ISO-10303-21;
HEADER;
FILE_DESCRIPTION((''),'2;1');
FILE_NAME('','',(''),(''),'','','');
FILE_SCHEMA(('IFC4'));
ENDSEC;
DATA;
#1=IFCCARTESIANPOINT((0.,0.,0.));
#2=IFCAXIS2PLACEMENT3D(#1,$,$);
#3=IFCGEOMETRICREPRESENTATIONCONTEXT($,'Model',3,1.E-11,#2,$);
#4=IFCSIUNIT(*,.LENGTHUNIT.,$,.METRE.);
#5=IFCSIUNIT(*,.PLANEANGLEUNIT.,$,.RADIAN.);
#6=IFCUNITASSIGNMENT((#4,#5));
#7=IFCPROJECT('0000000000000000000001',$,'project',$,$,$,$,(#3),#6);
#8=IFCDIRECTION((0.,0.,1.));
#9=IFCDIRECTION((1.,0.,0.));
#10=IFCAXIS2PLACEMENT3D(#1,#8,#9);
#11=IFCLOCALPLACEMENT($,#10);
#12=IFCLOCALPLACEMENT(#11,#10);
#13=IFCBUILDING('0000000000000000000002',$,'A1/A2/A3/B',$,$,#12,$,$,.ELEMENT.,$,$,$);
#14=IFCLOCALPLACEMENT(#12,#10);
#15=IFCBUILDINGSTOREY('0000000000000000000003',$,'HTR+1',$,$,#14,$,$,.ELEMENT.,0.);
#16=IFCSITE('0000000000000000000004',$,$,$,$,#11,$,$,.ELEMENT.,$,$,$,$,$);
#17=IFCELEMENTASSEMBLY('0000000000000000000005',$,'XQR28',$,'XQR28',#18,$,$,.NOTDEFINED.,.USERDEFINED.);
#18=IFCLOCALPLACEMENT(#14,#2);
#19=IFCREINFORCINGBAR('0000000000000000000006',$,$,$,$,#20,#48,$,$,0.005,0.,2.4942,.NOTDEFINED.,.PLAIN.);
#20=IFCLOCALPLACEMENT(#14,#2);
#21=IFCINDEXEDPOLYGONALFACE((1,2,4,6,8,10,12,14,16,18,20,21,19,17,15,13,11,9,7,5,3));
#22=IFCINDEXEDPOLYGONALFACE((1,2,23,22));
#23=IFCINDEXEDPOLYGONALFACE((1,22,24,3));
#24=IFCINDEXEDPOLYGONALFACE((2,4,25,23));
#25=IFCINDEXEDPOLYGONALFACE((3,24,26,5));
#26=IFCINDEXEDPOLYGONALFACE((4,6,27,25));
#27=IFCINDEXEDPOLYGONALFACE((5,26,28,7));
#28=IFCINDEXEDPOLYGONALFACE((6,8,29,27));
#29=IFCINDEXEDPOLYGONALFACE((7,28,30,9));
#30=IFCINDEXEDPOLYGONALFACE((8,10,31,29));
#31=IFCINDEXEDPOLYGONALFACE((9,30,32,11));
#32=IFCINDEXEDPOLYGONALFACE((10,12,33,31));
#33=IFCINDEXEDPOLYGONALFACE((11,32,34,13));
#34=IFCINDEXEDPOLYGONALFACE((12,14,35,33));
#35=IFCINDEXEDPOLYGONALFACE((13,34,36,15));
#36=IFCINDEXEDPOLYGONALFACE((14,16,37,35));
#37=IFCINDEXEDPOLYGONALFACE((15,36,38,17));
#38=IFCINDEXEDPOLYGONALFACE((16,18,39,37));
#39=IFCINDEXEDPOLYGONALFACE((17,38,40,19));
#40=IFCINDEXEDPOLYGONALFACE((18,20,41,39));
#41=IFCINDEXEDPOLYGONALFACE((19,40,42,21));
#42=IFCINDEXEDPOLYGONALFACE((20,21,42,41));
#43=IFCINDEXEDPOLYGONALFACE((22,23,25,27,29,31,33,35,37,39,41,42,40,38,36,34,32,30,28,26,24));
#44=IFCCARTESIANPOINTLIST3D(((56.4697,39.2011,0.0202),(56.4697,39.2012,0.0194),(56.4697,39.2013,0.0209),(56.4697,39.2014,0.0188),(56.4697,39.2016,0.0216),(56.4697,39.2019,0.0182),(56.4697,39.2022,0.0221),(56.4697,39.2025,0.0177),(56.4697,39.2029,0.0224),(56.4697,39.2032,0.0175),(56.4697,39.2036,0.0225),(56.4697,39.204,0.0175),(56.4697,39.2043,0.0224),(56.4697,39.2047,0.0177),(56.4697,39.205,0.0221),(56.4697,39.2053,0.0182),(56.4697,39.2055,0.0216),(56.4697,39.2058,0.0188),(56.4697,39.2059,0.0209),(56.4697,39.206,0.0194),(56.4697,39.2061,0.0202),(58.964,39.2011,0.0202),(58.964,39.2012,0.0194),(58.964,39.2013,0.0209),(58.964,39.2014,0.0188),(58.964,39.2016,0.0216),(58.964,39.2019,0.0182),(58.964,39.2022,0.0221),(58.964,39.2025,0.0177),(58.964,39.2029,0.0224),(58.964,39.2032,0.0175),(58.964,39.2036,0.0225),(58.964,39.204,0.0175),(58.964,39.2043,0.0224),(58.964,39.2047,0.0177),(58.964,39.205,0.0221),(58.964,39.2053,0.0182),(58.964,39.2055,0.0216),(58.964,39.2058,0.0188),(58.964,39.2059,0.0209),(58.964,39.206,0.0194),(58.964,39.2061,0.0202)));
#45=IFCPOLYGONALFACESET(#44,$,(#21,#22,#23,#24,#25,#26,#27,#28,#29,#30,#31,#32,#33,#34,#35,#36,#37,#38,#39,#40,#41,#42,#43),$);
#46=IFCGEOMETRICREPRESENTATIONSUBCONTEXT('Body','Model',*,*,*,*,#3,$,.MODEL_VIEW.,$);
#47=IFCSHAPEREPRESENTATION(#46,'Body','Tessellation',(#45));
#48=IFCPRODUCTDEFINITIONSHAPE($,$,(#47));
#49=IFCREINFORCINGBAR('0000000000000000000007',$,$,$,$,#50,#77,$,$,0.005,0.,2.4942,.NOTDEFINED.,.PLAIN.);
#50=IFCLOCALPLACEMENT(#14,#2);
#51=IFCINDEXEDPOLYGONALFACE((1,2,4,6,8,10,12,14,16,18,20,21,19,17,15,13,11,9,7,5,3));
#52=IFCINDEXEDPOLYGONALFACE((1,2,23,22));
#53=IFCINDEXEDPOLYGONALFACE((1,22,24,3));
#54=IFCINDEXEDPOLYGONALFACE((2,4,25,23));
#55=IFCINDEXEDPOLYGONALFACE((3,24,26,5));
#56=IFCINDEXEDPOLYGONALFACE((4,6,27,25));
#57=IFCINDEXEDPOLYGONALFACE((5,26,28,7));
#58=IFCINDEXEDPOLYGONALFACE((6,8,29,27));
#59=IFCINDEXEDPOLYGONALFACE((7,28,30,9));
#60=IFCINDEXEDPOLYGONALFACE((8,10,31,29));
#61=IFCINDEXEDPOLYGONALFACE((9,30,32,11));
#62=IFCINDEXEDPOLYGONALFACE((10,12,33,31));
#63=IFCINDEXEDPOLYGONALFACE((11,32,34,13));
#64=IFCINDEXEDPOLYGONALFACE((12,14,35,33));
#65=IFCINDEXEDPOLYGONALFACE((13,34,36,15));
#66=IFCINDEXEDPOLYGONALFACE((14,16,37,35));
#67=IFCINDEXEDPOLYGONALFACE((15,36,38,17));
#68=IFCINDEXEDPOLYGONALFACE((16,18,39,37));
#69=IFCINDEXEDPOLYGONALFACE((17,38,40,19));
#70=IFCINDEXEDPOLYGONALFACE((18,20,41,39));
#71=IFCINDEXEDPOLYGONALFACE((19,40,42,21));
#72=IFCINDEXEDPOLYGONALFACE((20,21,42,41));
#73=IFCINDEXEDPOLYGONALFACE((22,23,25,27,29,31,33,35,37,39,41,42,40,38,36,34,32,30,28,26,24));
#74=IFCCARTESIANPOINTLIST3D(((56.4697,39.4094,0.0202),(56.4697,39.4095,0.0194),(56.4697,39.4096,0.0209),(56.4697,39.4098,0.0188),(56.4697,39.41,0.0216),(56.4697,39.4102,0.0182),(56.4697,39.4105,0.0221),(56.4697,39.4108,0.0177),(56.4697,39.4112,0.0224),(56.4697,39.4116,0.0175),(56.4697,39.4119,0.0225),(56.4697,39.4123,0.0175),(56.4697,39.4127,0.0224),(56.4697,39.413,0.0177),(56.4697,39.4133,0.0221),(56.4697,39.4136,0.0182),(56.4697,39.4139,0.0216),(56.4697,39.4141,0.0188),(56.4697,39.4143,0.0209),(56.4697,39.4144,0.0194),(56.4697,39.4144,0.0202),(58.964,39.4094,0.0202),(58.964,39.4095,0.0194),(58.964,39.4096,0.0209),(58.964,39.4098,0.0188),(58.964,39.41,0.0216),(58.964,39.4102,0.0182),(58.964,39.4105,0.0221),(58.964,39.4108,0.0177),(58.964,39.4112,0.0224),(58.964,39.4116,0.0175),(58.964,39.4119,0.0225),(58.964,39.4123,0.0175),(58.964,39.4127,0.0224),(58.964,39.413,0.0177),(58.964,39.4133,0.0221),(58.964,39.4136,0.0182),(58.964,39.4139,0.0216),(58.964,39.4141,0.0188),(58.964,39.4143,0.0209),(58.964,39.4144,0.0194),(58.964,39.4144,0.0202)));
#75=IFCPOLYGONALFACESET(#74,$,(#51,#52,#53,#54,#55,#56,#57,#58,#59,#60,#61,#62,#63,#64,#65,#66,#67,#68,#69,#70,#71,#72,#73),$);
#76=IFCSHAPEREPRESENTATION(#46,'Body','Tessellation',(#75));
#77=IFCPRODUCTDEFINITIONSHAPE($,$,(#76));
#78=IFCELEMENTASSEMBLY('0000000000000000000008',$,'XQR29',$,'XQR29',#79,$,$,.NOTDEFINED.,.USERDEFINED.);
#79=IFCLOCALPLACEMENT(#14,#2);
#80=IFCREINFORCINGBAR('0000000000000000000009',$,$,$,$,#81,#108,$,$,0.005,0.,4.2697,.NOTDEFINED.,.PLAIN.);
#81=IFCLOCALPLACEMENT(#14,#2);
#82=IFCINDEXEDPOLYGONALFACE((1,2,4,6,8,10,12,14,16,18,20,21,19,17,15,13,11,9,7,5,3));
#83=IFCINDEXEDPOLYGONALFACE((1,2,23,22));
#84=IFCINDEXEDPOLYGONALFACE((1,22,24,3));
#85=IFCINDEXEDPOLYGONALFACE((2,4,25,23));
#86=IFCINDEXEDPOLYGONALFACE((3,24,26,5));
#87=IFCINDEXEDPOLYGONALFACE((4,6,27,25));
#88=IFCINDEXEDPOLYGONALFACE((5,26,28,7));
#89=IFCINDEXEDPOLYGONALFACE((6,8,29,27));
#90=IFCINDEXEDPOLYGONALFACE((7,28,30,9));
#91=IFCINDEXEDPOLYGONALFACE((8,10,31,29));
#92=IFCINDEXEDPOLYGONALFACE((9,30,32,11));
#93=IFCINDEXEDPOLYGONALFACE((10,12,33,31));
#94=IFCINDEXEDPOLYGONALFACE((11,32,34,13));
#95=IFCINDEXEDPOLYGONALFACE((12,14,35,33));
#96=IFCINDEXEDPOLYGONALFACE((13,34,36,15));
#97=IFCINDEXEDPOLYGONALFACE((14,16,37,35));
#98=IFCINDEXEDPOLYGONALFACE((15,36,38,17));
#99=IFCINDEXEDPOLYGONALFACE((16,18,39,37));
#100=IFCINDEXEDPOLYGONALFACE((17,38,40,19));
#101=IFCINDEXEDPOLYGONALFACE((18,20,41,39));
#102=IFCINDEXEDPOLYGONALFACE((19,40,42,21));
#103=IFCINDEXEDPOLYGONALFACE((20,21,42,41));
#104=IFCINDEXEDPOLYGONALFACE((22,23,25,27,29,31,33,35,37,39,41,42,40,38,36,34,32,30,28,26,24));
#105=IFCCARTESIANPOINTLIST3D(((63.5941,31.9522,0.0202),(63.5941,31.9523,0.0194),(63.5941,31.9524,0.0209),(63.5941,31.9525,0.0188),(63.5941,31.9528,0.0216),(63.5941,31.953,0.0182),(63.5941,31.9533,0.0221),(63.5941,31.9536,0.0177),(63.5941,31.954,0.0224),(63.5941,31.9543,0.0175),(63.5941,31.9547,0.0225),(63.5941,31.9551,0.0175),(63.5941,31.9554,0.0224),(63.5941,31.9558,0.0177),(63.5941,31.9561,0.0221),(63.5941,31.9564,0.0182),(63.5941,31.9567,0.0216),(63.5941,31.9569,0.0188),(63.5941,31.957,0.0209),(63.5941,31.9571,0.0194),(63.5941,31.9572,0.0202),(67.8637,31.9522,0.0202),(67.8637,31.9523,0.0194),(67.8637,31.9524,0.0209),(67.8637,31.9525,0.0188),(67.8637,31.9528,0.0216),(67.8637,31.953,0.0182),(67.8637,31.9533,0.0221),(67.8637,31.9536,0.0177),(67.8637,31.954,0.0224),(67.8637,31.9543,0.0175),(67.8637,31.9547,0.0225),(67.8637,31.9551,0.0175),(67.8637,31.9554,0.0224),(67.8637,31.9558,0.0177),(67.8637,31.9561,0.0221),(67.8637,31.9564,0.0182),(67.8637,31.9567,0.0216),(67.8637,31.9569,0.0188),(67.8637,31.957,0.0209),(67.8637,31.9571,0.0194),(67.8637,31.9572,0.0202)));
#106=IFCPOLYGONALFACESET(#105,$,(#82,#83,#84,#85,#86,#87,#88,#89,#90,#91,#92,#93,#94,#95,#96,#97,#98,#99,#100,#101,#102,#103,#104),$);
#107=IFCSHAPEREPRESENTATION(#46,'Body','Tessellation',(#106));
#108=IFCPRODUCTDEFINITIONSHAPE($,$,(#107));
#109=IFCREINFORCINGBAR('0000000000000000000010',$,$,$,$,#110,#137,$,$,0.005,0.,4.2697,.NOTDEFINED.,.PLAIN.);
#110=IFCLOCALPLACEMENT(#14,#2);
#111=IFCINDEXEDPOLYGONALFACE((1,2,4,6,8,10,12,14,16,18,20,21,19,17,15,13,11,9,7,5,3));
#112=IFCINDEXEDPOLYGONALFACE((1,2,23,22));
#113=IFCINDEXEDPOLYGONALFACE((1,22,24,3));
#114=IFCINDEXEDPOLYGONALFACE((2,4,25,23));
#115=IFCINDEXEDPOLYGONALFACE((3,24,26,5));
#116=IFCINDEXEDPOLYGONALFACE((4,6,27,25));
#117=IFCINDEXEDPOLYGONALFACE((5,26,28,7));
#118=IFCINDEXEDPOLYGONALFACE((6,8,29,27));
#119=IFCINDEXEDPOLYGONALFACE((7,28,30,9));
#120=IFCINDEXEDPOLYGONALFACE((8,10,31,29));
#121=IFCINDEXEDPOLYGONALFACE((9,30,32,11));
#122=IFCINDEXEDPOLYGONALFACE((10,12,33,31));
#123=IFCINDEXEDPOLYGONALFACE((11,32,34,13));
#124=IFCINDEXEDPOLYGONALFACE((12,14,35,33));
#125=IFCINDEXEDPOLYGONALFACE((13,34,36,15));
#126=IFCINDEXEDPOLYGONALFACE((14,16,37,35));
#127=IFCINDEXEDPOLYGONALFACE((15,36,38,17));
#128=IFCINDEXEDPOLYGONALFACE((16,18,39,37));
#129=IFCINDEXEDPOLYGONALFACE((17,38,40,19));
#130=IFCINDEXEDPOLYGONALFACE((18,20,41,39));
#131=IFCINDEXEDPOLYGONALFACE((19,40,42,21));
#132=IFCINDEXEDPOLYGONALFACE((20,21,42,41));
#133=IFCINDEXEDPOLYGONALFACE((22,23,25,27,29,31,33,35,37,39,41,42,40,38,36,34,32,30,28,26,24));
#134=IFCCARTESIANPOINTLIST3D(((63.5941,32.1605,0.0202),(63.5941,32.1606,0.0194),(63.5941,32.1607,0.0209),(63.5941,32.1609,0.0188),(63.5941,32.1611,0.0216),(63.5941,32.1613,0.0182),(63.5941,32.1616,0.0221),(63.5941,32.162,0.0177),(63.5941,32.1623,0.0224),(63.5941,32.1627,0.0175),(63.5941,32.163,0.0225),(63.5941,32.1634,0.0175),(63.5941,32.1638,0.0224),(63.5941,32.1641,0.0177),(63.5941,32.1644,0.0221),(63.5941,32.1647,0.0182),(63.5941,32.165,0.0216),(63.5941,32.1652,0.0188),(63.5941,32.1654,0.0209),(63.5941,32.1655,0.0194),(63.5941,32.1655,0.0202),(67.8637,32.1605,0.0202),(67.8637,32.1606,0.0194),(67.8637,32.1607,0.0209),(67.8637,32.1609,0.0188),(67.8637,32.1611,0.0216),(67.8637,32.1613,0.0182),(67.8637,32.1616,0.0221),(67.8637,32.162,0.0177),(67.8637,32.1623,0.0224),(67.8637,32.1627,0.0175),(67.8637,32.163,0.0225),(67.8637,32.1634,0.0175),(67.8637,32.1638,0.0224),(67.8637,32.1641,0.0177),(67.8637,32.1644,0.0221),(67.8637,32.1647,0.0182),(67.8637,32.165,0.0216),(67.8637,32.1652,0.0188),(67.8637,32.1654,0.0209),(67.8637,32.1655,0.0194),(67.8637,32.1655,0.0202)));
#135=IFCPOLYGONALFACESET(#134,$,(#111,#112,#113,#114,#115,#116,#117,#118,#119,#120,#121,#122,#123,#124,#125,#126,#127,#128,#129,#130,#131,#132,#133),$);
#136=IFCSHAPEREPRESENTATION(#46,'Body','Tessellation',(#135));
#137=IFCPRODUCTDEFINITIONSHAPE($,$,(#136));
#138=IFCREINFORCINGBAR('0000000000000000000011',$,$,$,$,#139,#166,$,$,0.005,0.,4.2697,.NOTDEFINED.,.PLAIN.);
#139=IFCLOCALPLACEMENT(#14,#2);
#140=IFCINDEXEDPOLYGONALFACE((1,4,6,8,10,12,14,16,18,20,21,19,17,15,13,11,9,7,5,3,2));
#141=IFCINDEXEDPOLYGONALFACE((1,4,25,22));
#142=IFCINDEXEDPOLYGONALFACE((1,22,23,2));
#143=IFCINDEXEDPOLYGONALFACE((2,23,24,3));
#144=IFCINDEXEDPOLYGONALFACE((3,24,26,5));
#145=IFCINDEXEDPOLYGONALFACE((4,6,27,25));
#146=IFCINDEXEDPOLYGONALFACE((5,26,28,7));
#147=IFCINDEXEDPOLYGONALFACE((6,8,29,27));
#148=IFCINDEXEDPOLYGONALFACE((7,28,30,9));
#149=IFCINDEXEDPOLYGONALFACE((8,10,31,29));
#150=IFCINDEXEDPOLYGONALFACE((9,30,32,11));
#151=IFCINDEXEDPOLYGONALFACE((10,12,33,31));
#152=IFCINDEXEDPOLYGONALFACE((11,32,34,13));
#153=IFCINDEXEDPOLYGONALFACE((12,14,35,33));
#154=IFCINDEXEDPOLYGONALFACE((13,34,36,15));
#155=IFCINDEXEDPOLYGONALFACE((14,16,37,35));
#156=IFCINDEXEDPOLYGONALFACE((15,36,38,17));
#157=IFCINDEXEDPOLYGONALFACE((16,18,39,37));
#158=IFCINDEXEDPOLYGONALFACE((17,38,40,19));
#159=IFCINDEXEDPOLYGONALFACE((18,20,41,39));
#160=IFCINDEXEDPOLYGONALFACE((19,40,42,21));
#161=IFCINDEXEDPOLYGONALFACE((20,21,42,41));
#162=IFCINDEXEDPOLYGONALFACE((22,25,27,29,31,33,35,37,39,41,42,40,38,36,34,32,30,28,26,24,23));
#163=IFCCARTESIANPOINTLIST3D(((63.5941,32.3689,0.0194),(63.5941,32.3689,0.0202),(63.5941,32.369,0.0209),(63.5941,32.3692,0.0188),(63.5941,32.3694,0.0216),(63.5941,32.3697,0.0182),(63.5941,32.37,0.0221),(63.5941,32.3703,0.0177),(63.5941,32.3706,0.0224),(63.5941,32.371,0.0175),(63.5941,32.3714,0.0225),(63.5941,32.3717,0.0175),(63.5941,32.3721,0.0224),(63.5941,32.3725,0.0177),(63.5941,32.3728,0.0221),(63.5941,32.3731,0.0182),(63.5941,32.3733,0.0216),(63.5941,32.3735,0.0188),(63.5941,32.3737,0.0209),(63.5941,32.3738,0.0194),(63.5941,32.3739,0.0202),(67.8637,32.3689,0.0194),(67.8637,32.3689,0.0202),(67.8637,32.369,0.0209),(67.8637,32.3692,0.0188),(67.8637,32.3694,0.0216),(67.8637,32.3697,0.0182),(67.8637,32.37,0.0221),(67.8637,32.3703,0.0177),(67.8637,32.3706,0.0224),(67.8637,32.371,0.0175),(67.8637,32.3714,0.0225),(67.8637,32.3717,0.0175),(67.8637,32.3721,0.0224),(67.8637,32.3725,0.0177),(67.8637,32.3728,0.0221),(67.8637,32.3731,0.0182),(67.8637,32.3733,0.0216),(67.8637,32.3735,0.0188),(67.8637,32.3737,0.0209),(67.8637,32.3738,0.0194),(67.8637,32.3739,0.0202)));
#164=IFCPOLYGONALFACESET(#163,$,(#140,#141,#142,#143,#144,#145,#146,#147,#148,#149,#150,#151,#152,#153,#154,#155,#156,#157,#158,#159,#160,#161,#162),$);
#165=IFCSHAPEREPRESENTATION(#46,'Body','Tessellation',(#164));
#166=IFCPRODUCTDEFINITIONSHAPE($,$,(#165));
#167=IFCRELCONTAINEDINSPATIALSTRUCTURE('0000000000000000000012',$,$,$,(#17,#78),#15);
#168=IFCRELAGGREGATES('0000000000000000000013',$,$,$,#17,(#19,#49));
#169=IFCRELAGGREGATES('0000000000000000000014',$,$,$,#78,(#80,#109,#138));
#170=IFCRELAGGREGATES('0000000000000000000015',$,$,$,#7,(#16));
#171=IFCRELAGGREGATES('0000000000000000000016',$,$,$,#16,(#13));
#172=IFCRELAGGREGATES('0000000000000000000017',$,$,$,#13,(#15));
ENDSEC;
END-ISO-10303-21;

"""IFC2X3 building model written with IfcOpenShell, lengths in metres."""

from ifc_helpers import new_model, entity, si_unit, origin, origin_with_axes, place, context, subcontext, project, spatial, shape, element, aggregate, save


model = new_model("IFC2X3")

# Units and contexts
model_context = context("Model", 3, precision=1e-11, world=origin())
body_context = subcontext(model_context, "Body", "Model", "MODEL_VIEW")
ifc_project = project(units=[si_unit("LENGTHUNIT", "METRE"), si_unit("PLANEANGLEUNIT", "RADIAN")], contexts=[model_context])

# Site, building, storey
site_placement = place(None, origin_with_axes())
site = spatial("IfcSite", under=ifc_project, at=site_placement, CompositionType="ELEMENT")
building_placement = place(site_placement, origin_with_axes())
building = spatial("IfcBuilding", under=site, at=building_placement, Name="A1/A2/A3/B", CompositionType="ELEMENT")
storey_placement = place(building_placement, origin_with_axes())
storey = spatial("IfcBuildingStorey", under=building, at=storey_placement, Name="HTR+1", CompositionType="ELEMENT", Elevation=0.0)

# Element assemblies, reinforcing bars
assembly_1_placement = place(storey_placement, origin_with_axes())
assembly_1 = element("IfcElementAssembly", 1, at=assembly_1_placement, inside=storey, Name="XQR28", ObjectType="XQR28", AssemblyPlace="NOTDEFINED", PredefinedType="USERDEFINED")
reinforcing_bar_1_placement = place(assembly_1_placement, origin_with_axes())
reinforcing_bar_1 = element("IfcReinforcingBar", 2, at=reinforcing_bar_1_placement, BarLength=2.4942, BarRole="NOTDEFINED", BarSurface="PLAIN", CrossSectionArea=0.0, NominalDiameter=0.005, shapes=[
    shape(body_context, "Body", "AdvancedSweptSolid", [entity("IfcSweptDiskSolid", entity("IfcPolyline", [entity("IfcCartesianPoint", [56.4697, 39.2036, 0.02]), entity("IfcCartesianPoint", [58.964, 39.2036, 0.02])]), 0.0025, None, 0.0, 2.4942)]),
    shape(body_context, "Body", "AdvancedSweptSolid", [entity("IfcSweptDiskSolid", entity("IfcPolyline", [entity("IfcCartesianPoint", [56.4697, 39.2036, 0.02]), entity("IfcCartesianPoint", [58.964, 39.2036, 0.02])]), 0.0025, None, 0.0, 2.4942)]),
])
reinforcing_bar_2_placement = place(assembly_1_placement, origin_with_axes())
reinforcing_bar_2 = element("IfcReinforcingBar", 3, at=reinforcing_bar_2_placement, BarLength=2.4942, BarRole="NOTDEFINED", BarSurface="PLAIN", CrossSectionArea=0.0, NominalDiameter=0.005, shapes=[
    shape(body_context, "Body", "AdvancedSweptSolid", [entity("IfcSweptDiskSolid", entity("IfcPolyline", [entity("IfcCartesianPoint", [56.4697, 39.4119, 0.02]), entity("IfcCartesianPoint", [58.964, 39.4119, 0.02])]), 0.0025, None, 0.0, 2.4942)]),
    shape(body_context, "Body", "AdvancedSweptSolid", [entity("IfcSweptDiskSolid", entity("IfcPolyline", [entity("IfcCartesianPoint", [56.4697, 39.4119, 0.02]), entity("IfcCartesianPoint", [58.964, 39.4119, 0.02])]), 0.0025, None, 0.0, 2.4942)]),
])
aggregate(assembly_1, [reinforcing_bar_1, reinforcing_bar_2])
assembly_2_placement = place(storey_placement, origin_with_axes())
assembly_2 = element("IfcElementAssembly", 4, at=assembly_2_placement, inside=storey, Name="XQR29", ObjectType="XQR29", AssemblyPlace="NOTDEFINED", PredefinedType="USERDEFINED")
reinforcing_bar_3_placement = place(assembly_2_placement, origin_with_axes())
reinforcing_bar_3 = element("IfcReinforcingBar", 5, at=reinforcing_bar_3_placement, BarLength=4.2697, BarRole="NOTDEFINED", BarSurface="PLAIN", CrossSectionArea=0.0, NominalDiameter=0.005, shapes=[
    shape(body_context, "Body", "AdvancedSweptSolid", [entity("IfcSweptDiskSolid", entity("IfcPolyline", [entity("IfcCartesianPoint", [63.5941, 31.9547, 0.02]), entity("IfcCartesianPoint", [67.8637, 31.9547, 0.02])]), 0.0025, None, 0.0, 4.2697)]),
    shape(body_context, "Body", "AdvancedSweptSolid", [entity("IfcSweptDiskSolid", entity("IfcPolyline", [entity("IfcCartesianPoint", [63.5941, 31.9547, 0.02]), entity("IfcCartesianPoint", [67.8637, 31.9547, 0.02])]), 0.0025, None, 0.0, 4.2697)]),
])
reinforcing_bar_4_placement = place(assembly_2_placement, origin_with_axes())
reinforcing_bar_4 = element("IfcReinforcingBar", 6, at=reinforcing_bar_4_placement, BarLength=4.2697, BarRole="NOTDEFINED", BarSurface="PLAIN", CrossSectionArea=0.0, NominalDiameter=0.005, shapes=[
    shape(body_context, "Body", "AdvancedSweptSolid", [entity("IfcSweptDiskSolid", entity("IfcPolyline", [entity("IfcCartesianPoint", [63.5941, 32.163, 0.02]), entity("IfcCartesianPoint", [67.8637, 32.163, 0.02])]), 0.0025, None, 0.0, 4.2697)]),
    shape(body_context, "Body", "AdvancedSweptSolid", [entity("IfcSweptDiskSolid", entity("IfcPolyline", [entity("IfcCartesianPoint", [63.5941, 32.163, 0.02]), entity("IfcCartesianPoint", [67.8637, 32.163, 0.02])]), 0.0025, None, 0.0, 4.2697)]),
])
reinforcing_bar_5_placement = place(assembly_2_placement, origin_with_axes())
reinforcing_bar_5 = element("IfcReinforcingBar", 7, at=reinforcing_bar_5_placement, BarLength=4.2697, BarRole="NOTDEFINED", BarSurface="PLAIN", CrossSectionArea=0.0, NominalDiameter=0.005, shapes=[
    shape(body_context, "Body", "AdvancedSweptSolid", [entity("IfcSweptDiskSolid", entity("IfcPolyline", [entity("IfcCartesianPoint", [63.5941, 32.3714, 0.02]), entity("IfcCartesianPoint", [67.8637, 32.3714, 0.02])]), 0.0025, None, 0.0, 4.2697)]),
    shape(body_context, "Body", "AdvancedSweptSolid", [entity("IfcSweptDiskSolid", entity("IfcPolyline", [entity("IfcCartesianPoint", [63.5941, 32.3714, 0.02]), entity("IfcCartesianPoint", [67.8637, 32.3714, 0.02])]), 0.0025, None, 0.0, 4.2697)]),
])
aggregate(assembly_2, [reinforcing_bar_3, reinforcing_bar_4, reinforcing_bar_5])

save(model, "model.ifc")
